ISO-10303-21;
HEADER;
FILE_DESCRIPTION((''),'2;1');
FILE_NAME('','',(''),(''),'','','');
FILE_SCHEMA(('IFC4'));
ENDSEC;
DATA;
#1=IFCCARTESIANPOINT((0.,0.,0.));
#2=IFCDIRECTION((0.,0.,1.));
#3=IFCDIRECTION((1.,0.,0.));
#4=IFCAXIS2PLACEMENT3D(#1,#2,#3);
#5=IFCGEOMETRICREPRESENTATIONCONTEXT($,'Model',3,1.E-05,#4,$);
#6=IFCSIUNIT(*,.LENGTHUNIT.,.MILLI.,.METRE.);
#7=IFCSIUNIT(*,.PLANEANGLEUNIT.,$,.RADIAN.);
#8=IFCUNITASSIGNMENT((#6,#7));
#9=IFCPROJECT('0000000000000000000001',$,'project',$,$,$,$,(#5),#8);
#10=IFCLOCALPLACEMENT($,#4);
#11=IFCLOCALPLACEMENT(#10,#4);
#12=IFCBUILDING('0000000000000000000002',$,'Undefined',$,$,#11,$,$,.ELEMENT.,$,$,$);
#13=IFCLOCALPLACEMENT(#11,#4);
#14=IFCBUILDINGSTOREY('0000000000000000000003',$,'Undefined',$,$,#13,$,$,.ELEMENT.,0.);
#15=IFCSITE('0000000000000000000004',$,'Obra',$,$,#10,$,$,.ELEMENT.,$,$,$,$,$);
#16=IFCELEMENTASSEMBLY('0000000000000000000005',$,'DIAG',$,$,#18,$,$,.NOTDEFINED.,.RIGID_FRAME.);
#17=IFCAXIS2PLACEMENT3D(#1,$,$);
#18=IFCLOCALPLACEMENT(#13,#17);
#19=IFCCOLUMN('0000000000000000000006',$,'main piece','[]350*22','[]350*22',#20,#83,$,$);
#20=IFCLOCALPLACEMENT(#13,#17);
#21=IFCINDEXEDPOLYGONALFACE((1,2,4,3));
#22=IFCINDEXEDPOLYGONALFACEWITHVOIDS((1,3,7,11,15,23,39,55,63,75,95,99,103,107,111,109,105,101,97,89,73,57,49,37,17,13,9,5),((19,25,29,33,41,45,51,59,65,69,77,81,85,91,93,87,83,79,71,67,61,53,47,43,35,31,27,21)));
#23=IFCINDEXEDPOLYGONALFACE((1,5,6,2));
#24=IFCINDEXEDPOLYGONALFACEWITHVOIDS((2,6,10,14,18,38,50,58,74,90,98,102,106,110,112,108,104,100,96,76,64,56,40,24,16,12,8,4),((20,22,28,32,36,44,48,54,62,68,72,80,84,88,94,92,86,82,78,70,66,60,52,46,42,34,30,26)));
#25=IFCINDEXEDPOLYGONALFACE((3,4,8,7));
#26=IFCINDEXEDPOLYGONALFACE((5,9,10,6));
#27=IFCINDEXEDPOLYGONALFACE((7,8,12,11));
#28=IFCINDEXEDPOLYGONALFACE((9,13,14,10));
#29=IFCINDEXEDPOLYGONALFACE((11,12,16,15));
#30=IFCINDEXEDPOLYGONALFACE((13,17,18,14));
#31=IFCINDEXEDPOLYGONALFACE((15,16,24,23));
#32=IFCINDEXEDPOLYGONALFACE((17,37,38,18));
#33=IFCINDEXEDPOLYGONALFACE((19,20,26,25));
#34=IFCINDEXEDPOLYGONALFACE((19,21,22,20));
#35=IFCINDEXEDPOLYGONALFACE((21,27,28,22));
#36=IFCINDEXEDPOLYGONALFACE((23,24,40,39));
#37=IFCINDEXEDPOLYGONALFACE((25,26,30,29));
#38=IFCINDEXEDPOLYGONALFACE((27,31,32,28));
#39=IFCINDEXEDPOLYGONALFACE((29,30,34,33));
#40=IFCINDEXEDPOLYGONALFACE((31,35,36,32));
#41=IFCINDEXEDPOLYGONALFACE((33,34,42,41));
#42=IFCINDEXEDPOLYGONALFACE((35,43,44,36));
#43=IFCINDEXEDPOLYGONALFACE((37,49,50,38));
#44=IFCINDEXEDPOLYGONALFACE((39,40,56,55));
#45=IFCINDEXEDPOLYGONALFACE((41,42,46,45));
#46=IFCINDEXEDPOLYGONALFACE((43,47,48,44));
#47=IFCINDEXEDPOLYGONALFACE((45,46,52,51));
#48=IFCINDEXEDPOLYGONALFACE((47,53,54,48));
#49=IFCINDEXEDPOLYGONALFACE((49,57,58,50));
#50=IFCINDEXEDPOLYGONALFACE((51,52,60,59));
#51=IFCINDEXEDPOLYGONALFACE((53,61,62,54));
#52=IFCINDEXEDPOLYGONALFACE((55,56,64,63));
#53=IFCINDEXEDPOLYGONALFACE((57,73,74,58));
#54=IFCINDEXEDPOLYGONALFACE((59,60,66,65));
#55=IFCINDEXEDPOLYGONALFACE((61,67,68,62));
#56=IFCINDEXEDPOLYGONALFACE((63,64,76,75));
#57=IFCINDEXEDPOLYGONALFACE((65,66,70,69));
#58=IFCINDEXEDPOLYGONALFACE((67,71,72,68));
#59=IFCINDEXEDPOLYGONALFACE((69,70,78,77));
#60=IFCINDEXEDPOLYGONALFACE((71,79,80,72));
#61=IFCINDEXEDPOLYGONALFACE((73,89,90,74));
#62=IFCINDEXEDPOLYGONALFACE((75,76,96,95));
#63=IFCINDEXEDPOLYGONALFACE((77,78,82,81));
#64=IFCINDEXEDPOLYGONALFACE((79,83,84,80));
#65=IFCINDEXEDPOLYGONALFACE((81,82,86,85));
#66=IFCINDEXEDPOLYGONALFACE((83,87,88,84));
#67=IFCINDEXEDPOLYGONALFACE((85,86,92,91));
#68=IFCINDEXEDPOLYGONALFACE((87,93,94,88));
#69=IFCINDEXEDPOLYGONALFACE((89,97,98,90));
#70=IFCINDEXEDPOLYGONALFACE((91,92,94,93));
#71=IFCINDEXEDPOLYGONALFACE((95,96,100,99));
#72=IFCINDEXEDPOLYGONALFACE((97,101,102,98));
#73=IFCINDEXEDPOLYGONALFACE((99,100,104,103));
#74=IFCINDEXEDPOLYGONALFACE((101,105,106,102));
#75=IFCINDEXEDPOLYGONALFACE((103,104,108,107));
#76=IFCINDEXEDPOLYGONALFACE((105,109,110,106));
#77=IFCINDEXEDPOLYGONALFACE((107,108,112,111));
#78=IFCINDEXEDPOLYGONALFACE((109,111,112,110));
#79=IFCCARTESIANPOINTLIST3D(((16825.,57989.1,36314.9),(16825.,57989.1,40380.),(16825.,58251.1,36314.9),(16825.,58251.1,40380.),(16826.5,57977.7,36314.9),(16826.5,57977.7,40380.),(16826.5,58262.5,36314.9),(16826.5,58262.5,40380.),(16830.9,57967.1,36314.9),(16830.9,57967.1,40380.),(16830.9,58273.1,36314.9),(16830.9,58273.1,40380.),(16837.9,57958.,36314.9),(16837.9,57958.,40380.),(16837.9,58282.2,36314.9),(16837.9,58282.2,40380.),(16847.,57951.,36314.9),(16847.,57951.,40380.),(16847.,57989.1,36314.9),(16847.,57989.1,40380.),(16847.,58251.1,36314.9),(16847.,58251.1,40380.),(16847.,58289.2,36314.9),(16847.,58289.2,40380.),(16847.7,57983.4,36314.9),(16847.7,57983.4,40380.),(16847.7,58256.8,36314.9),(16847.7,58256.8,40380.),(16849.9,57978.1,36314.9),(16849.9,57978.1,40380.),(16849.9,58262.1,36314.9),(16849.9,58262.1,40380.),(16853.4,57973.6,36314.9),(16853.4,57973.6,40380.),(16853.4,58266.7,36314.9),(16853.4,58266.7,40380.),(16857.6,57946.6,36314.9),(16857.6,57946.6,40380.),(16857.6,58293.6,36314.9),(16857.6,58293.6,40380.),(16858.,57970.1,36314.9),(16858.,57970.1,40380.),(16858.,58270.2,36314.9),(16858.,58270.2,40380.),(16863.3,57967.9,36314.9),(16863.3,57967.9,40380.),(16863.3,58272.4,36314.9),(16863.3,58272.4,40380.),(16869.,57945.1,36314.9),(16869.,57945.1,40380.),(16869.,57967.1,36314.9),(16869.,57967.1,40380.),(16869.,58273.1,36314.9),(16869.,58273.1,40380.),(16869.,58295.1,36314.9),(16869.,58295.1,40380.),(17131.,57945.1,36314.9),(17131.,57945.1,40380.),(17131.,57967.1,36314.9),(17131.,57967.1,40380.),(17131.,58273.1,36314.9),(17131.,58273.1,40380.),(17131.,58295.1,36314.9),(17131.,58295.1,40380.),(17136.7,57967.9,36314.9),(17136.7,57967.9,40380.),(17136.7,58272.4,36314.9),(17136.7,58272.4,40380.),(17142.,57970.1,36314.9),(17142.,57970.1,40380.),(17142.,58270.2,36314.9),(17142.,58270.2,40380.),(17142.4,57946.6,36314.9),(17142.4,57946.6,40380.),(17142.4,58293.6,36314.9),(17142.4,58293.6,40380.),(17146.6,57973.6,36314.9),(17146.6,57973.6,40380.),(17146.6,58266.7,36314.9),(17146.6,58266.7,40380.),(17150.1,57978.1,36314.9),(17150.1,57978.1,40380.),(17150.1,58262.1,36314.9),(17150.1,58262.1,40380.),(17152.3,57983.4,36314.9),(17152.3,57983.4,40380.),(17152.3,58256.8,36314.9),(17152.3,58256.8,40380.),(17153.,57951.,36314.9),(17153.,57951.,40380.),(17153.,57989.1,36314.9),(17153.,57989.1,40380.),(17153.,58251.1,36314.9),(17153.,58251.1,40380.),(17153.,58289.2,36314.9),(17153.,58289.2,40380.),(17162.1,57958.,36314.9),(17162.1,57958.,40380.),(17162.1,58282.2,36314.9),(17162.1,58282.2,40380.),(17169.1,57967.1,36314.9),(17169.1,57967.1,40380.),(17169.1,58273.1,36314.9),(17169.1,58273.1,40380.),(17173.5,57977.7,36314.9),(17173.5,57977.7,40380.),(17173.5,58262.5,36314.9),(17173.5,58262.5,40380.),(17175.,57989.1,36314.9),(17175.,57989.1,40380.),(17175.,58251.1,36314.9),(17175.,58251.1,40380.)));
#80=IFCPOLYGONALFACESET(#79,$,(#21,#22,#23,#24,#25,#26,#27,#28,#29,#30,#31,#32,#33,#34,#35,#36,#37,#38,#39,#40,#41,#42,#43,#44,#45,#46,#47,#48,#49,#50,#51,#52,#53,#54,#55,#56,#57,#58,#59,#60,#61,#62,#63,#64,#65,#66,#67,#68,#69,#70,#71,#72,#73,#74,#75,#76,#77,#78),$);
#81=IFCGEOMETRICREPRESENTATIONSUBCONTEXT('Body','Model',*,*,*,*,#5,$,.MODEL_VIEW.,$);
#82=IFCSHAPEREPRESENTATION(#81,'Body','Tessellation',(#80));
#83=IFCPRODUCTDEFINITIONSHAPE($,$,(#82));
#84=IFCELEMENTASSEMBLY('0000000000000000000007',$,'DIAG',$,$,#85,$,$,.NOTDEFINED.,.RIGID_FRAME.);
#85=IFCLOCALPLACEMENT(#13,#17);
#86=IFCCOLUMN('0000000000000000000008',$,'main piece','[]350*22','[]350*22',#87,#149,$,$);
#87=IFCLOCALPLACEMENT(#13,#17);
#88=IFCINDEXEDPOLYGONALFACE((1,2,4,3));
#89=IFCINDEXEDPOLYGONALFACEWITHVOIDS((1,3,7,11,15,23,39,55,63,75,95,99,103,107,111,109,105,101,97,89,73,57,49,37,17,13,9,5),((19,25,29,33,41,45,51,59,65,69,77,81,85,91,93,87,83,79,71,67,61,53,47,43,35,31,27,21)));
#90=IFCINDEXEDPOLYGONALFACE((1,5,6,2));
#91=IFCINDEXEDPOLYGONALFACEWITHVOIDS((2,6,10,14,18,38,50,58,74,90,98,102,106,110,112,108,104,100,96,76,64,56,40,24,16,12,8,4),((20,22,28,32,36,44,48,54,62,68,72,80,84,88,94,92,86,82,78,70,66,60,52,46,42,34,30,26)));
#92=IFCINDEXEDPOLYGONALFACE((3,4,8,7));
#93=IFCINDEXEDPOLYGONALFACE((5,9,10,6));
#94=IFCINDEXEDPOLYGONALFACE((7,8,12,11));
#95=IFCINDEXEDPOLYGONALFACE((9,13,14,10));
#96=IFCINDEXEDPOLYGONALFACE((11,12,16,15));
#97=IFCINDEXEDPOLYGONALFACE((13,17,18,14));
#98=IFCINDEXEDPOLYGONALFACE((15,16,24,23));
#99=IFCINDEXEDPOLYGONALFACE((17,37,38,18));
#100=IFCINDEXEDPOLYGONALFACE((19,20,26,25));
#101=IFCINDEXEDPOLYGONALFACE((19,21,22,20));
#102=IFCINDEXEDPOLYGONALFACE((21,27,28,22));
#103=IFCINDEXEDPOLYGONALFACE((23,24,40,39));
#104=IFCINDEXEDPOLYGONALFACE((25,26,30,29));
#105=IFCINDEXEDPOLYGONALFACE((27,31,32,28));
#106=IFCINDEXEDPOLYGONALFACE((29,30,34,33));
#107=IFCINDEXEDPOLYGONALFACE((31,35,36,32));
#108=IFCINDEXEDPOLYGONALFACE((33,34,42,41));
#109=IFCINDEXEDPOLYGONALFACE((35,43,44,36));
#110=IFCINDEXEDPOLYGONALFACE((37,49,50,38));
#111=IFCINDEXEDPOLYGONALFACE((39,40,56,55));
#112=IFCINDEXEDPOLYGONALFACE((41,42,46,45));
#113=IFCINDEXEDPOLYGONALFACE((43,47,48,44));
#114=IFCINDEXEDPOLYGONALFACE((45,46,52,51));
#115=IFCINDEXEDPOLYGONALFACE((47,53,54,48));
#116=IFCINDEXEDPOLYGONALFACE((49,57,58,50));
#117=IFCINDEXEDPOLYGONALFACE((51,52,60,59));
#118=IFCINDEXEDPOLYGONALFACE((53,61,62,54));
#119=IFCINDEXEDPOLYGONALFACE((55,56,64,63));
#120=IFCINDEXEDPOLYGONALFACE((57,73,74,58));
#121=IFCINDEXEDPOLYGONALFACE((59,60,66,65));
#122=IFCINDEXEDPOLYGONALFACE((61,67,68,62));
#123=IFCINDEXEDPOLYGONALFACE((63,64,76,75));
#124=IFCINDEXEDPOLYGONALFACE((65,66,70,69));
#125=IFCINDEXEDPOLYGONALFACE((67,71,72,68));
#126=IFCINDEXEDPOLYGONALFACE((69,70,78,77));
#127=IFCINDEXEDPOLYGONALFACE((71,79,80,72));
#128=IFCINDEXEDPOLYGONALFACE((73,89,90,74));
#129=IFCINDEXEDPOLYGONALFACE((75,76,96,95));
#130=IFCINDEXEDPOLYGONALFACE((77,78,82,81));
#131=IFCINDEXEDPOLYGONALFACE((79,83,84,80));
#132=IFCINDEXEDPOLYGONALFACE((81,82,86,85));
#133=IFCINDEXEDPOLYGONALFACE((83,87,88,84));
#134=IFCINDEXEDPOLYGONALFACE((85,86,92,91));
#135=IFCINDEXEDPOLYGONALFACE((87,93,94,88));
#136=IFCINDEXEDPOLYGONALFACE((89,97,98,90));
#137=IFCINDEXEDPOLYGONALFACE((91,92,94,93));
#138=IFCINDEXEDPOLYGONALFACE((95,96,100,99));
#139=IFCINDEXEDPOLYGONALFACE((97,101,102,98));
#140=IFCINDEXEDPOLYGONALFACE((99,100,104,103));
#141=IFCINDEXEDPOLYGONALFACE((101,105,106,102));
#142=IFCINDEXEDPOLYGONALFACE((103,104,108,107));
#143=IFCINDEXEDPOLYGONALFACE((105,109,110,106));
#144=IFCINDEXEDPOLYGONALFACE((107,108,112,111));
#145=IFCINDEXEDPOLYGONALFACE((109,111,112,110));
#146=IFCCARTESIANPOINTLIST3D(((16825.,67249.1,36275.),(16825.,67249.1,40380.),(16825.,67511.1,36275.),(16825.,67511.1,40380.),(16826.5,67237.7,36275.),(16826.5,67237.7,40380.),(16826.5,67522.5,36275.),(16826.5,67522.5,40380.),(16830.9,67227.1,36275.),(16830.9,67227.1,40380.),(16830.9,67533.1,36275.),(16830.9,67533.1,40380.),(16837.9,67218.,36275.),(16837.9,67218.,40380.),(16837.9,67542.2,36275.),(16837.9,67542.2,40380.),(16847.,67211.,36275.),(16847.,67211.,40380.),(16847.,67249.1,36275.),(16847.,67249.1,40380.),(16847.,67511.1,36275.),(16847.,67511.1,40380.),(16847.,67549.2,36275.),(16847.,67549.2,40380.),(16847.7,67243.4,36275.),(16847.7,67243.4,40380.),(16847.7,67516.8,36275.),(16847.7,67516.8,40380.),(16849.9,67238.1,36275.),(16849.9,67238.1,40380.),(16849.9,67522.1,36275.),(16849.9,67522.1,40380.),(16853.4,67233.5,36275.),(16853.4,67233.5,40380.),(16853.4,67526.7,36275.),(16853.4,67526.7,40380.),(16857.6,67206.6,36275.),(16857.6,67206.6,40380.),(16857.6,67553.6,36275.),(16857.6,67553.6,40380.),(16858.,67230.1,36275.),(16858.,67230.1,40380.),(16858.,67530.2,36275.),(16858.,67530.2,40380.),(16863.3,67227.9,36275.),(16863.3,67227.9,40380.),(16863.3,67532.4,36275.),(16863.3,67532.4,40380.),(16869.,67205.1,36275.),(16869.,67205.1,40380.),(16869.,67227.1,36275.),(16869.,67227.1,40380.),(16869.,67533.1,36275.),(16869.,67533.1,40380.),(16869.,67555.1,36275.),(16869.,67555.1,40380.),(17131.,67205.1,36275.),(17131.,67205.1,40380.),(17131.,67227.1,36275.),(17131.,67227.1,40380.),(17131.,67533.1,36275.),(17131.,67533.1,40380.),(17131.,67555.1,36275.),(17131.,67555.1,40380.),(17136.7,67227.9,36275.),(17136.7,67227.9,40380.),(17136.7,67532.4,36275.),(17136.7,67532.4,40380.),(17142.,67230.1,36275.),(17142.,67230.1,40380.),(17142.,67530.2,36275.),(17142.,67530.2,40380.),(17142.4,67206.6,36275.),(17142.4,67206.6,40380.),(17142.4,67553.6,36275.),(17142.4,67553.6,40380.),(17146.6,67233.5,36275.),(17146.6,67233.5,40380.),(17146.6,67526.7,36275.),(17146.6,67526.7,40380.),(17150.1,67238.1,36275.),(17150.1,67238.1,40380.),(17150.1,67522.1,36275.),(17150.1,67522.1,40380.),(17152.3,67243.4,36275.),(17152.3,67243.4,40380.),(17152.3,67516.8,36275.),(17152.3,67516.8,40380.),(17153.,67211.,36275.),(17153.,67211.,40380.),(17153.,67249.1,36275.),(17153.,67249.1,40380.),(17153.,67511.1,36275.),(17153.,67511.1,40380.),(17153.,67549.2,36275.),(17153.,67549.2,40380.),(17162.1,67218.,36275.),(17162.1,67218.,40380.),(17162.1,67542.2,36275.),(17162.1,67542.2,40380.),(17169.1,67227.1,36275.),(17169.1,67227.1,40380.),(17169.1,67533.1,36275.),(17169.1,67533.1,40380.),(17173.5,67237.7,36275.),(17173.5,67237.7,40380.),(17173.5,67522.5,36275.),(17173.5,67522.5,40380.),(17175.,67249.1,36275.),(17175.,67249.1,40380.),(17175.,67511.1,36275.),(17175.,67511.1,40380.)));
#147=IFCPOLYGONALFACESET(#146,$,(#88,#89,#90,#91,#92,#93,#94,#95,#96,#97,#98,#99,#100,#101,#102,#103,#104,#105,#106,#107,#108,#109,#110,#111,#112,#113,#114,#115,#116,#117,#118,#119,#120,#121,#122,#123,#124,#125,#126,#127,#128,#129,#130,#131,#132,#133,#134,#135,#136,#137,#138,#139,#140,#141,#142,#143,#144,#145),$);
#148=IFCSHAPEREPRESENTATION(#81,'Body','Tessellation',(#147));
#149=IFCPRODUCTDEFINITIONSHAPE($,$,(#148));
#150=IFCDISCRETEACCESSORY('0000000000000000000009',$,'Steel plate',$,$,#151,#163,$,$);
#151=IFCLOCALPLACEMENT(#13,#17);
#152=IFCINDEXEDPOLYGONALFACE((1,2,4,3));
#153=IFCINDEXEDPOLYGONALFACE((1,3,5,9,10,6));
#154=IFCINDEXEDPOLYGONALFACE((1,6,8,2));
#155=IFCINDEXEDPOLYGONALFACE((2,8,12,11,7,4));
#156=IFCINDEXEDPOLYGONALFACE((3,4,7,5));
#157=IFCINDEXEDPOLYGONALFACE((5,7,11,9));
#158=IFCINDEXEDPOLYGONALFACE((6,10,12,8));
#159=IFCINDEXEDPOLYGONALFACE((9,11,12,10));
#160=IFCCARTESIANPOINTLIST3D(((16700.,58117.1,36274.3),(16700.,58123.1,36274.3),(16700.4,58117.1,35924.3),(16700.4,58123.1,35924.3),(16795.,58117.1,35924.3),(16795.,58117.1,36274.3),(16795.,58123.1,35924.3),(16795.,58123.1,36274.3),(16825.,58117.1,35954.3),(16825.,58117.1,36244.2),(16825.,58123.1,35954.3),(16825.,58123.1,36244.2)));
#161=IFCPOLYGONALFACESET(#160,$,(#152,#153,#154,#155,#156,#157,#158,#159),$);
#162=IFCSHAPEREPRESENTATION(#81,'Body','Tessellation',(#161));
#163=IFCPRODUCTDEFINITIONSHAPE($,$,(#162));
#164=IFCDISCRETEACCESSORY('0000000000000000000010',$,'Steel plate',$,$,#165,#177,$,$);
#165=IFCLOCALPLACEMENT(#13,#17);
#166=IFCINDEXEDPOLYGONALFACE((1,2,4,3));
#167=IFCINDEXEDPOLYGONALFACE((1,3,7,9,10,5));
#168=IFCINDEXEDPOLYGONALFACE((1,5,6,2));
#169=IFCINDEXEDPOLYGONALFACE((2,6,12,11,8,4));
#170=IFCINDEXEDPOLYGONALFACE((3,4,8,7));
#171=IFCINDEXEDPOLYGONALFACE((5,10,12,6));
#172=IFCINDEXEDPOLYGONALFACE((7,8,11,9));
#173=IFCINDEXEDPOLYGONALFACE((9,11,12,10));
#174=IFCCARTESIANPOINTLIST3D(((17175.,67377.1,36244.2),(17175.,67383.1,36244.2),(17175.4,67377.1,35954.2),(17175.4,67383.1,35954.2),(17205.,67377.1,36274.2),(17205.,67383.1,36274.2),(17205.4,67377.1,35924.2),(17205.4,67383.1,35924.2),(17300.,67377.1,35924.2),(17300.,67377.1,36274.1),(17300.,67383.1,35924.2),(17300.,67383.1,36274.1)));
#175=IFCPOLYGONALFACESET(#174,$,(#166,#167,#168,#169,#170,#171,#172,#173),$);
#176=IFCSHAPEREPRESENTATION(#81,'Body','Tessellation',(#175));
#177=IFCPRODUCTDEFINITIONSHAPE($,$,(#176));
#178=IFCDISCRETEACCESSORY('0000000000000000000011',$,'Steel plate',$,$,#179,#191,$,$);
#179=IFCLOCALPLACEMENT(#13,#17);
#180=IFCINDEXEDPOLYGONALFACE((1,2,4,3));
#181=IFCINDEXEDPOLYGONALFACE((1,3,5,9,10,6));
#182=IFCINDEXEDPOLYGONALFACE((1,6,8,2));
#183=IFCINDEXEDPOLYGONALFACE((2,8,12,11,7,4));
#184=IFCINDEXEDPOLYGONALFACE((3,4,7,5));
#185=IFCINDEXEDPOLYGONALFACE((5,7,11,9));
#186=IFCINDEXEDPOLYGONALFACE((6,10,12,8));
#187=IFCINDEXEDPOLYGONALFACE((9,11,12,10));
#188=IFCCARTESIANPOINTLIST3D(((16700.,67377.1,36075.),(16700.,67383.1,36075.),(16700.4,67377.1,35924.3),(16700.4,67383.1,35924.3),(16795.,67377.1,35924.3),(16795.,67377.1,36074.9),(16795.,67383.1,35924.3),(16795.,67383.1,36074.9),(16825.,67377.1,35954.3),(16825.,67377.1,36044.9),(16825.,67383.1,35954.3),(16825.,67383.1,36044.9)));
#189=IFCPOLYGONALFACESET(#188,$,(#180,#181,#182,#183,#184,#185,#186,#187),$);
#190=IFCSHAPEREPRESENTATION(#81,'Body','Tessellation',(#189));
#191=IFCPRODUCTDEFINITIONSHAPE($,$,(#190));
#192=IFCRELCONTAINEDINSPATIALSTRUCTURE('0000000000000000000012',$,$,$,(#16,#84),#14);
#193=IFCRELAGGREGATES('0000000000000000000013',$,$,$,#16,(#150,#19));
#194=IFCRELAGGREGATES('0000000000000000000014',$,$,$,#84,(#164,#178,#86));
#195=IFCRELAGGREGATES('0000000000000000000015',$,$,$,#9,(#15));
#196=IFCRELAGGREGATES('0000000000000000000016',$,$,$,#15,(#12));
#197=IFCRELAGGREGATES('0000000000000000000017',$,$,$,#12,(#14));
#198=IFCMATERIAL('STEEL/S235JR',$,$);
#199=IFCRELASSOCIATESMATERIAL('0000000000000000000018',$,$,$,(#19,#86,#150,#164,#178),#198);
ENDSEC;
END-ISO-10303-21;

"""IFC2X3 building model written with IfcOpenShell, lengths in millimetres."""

from ifc_helpers import new_model, si_unit, frame, origin_with_axes, origin_2d_with_axis, place, context, subcontext, project, spatial, polyline, hollow_rectangle, outline, extrude, material, element, aggregate, save


model = new_model("IFC2X3")

# Units and contexts
model_context = context("Model", 3, precision=1e-05, world=origin_with_axes())
body_context = subcontext(model_context, "Body", "Model", "MODEL_VIEW")
ifc_project = project(units=[si_unit("LENGTHUNIT", "METRE", prefix="MILLI"), si_unit("PLANEANGLEUNIT", "RADIAN")], contexts=[model_context])

# Site, building, storey
site_placement = place(None, origin_with_axes())
site = spatial("IfcSite", under=ifc_project, at=site_placement, Name="Obra", CompositionType="ELEMENT")
building_placement = place(site_placement, origin_with_axes())
building = spatial("IfcBuilding", under=site, at=building_placement, Name="Undefined", CompositionType="ELEMENT")
storey_placement = place(building_placement, origin_with_axes())
storey = spatial("IfcBuildingStorey", under=building, at=storey_placement, Name="Undefined", CompositionType="ELEMENT", Elevation=0.0)

# Element assemblies, columns
assembly_1_placement = place(storey_placement, origin_with_axes())
assembly_1 = element("IfcElementAssembly", 1, at=assembly_1_placement, inside=storey, Name="DIAG", AssemblyPlace="NOTDEFINED", PredefinedType="RIGID_FRAME")
ifc_material_1 = material(Name="STEEL/S235JR")
column_1_placement = place(assembly_1_placement, frame((17000.0, 58120.1, 36314.8), z_axis=(0.0, 0.0, 1.0), x_axis=(-1.0, 0.0, 0.0)))
column_1 = element("IfcColumn", 2, at=column_1_placement, material=ifc_material_1, Name="main piece", Description="[]350*22", ObjectType="[]350*22", context=body_context, shape_type="SweptSolid", body=[
    extrude(hollow_rectangle(XDim=350.0, YDim=350.0, WallThickness=22.0, InnerFilletRadius=22.0, OuterFilletRadius=44.0, at=origin_2d_with_axis()), frame((0.0, 0.0, 4065.2), z_axis=(0.0, 0.0, -1.0), x_axis=(0.0, 1.0, 0.0)), (0.0, 0.0, 1.0), 4065.2),
])
assembly_2_placement = place(storey_placement, origin_with_axes())
assembly_2 = element("IfcElementAssembly", 3, at=assembly_2_placement, inside=storey, Name="DIAG", AssemblyPlace="NOTDEFINED", PredefinedType="RIGID_FRAME")
column_2_placement = place(assembly_2_placement, frame((17000.0, 67380.1, 36275.0), z_axis=(0.0, 0.0, 1.0), x_axis=(-1.0, 0.0, 0.0)))
column_2 = element("IfcColumn", 4, at=column_2_placement, material=ifc_material_1, Name="main piece", Description="[]350*22", ObjectType="[]350*22", context=body_context, shape_type="SweptSolid", body=[
    extrude(hollow_rectangle(XDim=350.0, YDim=350.0, WallThickness=22.0, InnerFilletRadius=22.0, OuterFilletRadius=44.0, at=origin_2d_with_axis()), frame((0.0, 0.0, 4105.0), z_axis=(0.0, 0.0, -1.0), x_axis=(0.0, 1.0, 0.0)), (0.0, 0.0, 1.0), 4105.0),
])

# Discrete accessory
discrete_accessory_1_placement = place(assembly_1_placement, frame((16825.0, 58120.1, 35924.3), z_axis=(0.0, 1.0, 0.0), x_axis=(-1.0, 0.0, 0.0)))
discrete_accessory_1 = element("IfcDiscreteAccessory", 5, at=discrete_accessory_1_placement, material=ifc_material_1, Name="Steel plate", context=body_context, shape_type="SweptSolid", body=[
    extrude(outline(polyline([(0.0, 30.0), (30.0, 0.0), (124.6, 0.0), (125.0, 350.0), (30.0, 349.9), (0.0, 319.9), (0.0, 30.0)])), frame((0.0, 0.0, -3.0), z_axis=(0.0, 0.0, 1.0), x_axis=(1.0, 0.0, 0.0)), (0.0, 0.0, 1.0), 6.0),
])

# Discrete accessories
discrete_accessory_2_placement = place(assembly_2_placement, frame((17300.0, 67380.1, 35924.2), z_axis=(0.0, 1.0, 0.0), x_axis=(-1.0, 0.0, 0.0)))
discrete_accessory_2 = element("IfcDiscreteAccessory", 6, at=discrete_accessory_2_placement, material=ifc_material_1, Name="Steel plate", context=body_context, shape_type="SweptSolid", body=[
    extrude(outline(polyline([(0.0, 0.0), (94.6, 0.0), (124.6, 30.0), (125.0, 320.0), (95.0, 350.0), (0.0, 349.9), (0.0, 0.0)])), frame((0.0, 0.0, -3.0), z_axis=(0.0, 0.0, 1.0), x_axis=(1.0, 0.0, 0.0)), (0.0, 0.0, 1.0), 6.0),
])
discrete_accessory_3_placement = place(assembly_2_placement, frame((16825.0, 67380.1, 35924.3), z_axis=(0.0, 1.0, 0.0), x_axis=(-1.0, 0.0, 0.0)))
discrete_accessory_3 = element("IfcDiscreteAccessory", 7, at=discrete_accessory_3_placement, material=ifc_material_1, Name="Steel plate", context=body_context, shape_type="SweptSolid", body=[
    extrude(outline(polyline([(0.0, 30.0), (30.0, 0.0), (124.6, 0.0), (125.0, 150.7), (30.0, 150.6), (0.0, 120.5), (0.0, 30.0)])), frame((0.0, 0.0, -3.0), z_axis=(0.0, 0.0, 1.0), x_axis=(1.0, 0.0, 0.0)), (0.0, 0.0, 1.0), 6.0),
])

aggregate(assembly_1, [discrete_accessory_1, column_1])

aggregate(assembly_2, [discrete_accessory_2, discrete_accessory_3, column_2])

save(model, "model.ifc")
